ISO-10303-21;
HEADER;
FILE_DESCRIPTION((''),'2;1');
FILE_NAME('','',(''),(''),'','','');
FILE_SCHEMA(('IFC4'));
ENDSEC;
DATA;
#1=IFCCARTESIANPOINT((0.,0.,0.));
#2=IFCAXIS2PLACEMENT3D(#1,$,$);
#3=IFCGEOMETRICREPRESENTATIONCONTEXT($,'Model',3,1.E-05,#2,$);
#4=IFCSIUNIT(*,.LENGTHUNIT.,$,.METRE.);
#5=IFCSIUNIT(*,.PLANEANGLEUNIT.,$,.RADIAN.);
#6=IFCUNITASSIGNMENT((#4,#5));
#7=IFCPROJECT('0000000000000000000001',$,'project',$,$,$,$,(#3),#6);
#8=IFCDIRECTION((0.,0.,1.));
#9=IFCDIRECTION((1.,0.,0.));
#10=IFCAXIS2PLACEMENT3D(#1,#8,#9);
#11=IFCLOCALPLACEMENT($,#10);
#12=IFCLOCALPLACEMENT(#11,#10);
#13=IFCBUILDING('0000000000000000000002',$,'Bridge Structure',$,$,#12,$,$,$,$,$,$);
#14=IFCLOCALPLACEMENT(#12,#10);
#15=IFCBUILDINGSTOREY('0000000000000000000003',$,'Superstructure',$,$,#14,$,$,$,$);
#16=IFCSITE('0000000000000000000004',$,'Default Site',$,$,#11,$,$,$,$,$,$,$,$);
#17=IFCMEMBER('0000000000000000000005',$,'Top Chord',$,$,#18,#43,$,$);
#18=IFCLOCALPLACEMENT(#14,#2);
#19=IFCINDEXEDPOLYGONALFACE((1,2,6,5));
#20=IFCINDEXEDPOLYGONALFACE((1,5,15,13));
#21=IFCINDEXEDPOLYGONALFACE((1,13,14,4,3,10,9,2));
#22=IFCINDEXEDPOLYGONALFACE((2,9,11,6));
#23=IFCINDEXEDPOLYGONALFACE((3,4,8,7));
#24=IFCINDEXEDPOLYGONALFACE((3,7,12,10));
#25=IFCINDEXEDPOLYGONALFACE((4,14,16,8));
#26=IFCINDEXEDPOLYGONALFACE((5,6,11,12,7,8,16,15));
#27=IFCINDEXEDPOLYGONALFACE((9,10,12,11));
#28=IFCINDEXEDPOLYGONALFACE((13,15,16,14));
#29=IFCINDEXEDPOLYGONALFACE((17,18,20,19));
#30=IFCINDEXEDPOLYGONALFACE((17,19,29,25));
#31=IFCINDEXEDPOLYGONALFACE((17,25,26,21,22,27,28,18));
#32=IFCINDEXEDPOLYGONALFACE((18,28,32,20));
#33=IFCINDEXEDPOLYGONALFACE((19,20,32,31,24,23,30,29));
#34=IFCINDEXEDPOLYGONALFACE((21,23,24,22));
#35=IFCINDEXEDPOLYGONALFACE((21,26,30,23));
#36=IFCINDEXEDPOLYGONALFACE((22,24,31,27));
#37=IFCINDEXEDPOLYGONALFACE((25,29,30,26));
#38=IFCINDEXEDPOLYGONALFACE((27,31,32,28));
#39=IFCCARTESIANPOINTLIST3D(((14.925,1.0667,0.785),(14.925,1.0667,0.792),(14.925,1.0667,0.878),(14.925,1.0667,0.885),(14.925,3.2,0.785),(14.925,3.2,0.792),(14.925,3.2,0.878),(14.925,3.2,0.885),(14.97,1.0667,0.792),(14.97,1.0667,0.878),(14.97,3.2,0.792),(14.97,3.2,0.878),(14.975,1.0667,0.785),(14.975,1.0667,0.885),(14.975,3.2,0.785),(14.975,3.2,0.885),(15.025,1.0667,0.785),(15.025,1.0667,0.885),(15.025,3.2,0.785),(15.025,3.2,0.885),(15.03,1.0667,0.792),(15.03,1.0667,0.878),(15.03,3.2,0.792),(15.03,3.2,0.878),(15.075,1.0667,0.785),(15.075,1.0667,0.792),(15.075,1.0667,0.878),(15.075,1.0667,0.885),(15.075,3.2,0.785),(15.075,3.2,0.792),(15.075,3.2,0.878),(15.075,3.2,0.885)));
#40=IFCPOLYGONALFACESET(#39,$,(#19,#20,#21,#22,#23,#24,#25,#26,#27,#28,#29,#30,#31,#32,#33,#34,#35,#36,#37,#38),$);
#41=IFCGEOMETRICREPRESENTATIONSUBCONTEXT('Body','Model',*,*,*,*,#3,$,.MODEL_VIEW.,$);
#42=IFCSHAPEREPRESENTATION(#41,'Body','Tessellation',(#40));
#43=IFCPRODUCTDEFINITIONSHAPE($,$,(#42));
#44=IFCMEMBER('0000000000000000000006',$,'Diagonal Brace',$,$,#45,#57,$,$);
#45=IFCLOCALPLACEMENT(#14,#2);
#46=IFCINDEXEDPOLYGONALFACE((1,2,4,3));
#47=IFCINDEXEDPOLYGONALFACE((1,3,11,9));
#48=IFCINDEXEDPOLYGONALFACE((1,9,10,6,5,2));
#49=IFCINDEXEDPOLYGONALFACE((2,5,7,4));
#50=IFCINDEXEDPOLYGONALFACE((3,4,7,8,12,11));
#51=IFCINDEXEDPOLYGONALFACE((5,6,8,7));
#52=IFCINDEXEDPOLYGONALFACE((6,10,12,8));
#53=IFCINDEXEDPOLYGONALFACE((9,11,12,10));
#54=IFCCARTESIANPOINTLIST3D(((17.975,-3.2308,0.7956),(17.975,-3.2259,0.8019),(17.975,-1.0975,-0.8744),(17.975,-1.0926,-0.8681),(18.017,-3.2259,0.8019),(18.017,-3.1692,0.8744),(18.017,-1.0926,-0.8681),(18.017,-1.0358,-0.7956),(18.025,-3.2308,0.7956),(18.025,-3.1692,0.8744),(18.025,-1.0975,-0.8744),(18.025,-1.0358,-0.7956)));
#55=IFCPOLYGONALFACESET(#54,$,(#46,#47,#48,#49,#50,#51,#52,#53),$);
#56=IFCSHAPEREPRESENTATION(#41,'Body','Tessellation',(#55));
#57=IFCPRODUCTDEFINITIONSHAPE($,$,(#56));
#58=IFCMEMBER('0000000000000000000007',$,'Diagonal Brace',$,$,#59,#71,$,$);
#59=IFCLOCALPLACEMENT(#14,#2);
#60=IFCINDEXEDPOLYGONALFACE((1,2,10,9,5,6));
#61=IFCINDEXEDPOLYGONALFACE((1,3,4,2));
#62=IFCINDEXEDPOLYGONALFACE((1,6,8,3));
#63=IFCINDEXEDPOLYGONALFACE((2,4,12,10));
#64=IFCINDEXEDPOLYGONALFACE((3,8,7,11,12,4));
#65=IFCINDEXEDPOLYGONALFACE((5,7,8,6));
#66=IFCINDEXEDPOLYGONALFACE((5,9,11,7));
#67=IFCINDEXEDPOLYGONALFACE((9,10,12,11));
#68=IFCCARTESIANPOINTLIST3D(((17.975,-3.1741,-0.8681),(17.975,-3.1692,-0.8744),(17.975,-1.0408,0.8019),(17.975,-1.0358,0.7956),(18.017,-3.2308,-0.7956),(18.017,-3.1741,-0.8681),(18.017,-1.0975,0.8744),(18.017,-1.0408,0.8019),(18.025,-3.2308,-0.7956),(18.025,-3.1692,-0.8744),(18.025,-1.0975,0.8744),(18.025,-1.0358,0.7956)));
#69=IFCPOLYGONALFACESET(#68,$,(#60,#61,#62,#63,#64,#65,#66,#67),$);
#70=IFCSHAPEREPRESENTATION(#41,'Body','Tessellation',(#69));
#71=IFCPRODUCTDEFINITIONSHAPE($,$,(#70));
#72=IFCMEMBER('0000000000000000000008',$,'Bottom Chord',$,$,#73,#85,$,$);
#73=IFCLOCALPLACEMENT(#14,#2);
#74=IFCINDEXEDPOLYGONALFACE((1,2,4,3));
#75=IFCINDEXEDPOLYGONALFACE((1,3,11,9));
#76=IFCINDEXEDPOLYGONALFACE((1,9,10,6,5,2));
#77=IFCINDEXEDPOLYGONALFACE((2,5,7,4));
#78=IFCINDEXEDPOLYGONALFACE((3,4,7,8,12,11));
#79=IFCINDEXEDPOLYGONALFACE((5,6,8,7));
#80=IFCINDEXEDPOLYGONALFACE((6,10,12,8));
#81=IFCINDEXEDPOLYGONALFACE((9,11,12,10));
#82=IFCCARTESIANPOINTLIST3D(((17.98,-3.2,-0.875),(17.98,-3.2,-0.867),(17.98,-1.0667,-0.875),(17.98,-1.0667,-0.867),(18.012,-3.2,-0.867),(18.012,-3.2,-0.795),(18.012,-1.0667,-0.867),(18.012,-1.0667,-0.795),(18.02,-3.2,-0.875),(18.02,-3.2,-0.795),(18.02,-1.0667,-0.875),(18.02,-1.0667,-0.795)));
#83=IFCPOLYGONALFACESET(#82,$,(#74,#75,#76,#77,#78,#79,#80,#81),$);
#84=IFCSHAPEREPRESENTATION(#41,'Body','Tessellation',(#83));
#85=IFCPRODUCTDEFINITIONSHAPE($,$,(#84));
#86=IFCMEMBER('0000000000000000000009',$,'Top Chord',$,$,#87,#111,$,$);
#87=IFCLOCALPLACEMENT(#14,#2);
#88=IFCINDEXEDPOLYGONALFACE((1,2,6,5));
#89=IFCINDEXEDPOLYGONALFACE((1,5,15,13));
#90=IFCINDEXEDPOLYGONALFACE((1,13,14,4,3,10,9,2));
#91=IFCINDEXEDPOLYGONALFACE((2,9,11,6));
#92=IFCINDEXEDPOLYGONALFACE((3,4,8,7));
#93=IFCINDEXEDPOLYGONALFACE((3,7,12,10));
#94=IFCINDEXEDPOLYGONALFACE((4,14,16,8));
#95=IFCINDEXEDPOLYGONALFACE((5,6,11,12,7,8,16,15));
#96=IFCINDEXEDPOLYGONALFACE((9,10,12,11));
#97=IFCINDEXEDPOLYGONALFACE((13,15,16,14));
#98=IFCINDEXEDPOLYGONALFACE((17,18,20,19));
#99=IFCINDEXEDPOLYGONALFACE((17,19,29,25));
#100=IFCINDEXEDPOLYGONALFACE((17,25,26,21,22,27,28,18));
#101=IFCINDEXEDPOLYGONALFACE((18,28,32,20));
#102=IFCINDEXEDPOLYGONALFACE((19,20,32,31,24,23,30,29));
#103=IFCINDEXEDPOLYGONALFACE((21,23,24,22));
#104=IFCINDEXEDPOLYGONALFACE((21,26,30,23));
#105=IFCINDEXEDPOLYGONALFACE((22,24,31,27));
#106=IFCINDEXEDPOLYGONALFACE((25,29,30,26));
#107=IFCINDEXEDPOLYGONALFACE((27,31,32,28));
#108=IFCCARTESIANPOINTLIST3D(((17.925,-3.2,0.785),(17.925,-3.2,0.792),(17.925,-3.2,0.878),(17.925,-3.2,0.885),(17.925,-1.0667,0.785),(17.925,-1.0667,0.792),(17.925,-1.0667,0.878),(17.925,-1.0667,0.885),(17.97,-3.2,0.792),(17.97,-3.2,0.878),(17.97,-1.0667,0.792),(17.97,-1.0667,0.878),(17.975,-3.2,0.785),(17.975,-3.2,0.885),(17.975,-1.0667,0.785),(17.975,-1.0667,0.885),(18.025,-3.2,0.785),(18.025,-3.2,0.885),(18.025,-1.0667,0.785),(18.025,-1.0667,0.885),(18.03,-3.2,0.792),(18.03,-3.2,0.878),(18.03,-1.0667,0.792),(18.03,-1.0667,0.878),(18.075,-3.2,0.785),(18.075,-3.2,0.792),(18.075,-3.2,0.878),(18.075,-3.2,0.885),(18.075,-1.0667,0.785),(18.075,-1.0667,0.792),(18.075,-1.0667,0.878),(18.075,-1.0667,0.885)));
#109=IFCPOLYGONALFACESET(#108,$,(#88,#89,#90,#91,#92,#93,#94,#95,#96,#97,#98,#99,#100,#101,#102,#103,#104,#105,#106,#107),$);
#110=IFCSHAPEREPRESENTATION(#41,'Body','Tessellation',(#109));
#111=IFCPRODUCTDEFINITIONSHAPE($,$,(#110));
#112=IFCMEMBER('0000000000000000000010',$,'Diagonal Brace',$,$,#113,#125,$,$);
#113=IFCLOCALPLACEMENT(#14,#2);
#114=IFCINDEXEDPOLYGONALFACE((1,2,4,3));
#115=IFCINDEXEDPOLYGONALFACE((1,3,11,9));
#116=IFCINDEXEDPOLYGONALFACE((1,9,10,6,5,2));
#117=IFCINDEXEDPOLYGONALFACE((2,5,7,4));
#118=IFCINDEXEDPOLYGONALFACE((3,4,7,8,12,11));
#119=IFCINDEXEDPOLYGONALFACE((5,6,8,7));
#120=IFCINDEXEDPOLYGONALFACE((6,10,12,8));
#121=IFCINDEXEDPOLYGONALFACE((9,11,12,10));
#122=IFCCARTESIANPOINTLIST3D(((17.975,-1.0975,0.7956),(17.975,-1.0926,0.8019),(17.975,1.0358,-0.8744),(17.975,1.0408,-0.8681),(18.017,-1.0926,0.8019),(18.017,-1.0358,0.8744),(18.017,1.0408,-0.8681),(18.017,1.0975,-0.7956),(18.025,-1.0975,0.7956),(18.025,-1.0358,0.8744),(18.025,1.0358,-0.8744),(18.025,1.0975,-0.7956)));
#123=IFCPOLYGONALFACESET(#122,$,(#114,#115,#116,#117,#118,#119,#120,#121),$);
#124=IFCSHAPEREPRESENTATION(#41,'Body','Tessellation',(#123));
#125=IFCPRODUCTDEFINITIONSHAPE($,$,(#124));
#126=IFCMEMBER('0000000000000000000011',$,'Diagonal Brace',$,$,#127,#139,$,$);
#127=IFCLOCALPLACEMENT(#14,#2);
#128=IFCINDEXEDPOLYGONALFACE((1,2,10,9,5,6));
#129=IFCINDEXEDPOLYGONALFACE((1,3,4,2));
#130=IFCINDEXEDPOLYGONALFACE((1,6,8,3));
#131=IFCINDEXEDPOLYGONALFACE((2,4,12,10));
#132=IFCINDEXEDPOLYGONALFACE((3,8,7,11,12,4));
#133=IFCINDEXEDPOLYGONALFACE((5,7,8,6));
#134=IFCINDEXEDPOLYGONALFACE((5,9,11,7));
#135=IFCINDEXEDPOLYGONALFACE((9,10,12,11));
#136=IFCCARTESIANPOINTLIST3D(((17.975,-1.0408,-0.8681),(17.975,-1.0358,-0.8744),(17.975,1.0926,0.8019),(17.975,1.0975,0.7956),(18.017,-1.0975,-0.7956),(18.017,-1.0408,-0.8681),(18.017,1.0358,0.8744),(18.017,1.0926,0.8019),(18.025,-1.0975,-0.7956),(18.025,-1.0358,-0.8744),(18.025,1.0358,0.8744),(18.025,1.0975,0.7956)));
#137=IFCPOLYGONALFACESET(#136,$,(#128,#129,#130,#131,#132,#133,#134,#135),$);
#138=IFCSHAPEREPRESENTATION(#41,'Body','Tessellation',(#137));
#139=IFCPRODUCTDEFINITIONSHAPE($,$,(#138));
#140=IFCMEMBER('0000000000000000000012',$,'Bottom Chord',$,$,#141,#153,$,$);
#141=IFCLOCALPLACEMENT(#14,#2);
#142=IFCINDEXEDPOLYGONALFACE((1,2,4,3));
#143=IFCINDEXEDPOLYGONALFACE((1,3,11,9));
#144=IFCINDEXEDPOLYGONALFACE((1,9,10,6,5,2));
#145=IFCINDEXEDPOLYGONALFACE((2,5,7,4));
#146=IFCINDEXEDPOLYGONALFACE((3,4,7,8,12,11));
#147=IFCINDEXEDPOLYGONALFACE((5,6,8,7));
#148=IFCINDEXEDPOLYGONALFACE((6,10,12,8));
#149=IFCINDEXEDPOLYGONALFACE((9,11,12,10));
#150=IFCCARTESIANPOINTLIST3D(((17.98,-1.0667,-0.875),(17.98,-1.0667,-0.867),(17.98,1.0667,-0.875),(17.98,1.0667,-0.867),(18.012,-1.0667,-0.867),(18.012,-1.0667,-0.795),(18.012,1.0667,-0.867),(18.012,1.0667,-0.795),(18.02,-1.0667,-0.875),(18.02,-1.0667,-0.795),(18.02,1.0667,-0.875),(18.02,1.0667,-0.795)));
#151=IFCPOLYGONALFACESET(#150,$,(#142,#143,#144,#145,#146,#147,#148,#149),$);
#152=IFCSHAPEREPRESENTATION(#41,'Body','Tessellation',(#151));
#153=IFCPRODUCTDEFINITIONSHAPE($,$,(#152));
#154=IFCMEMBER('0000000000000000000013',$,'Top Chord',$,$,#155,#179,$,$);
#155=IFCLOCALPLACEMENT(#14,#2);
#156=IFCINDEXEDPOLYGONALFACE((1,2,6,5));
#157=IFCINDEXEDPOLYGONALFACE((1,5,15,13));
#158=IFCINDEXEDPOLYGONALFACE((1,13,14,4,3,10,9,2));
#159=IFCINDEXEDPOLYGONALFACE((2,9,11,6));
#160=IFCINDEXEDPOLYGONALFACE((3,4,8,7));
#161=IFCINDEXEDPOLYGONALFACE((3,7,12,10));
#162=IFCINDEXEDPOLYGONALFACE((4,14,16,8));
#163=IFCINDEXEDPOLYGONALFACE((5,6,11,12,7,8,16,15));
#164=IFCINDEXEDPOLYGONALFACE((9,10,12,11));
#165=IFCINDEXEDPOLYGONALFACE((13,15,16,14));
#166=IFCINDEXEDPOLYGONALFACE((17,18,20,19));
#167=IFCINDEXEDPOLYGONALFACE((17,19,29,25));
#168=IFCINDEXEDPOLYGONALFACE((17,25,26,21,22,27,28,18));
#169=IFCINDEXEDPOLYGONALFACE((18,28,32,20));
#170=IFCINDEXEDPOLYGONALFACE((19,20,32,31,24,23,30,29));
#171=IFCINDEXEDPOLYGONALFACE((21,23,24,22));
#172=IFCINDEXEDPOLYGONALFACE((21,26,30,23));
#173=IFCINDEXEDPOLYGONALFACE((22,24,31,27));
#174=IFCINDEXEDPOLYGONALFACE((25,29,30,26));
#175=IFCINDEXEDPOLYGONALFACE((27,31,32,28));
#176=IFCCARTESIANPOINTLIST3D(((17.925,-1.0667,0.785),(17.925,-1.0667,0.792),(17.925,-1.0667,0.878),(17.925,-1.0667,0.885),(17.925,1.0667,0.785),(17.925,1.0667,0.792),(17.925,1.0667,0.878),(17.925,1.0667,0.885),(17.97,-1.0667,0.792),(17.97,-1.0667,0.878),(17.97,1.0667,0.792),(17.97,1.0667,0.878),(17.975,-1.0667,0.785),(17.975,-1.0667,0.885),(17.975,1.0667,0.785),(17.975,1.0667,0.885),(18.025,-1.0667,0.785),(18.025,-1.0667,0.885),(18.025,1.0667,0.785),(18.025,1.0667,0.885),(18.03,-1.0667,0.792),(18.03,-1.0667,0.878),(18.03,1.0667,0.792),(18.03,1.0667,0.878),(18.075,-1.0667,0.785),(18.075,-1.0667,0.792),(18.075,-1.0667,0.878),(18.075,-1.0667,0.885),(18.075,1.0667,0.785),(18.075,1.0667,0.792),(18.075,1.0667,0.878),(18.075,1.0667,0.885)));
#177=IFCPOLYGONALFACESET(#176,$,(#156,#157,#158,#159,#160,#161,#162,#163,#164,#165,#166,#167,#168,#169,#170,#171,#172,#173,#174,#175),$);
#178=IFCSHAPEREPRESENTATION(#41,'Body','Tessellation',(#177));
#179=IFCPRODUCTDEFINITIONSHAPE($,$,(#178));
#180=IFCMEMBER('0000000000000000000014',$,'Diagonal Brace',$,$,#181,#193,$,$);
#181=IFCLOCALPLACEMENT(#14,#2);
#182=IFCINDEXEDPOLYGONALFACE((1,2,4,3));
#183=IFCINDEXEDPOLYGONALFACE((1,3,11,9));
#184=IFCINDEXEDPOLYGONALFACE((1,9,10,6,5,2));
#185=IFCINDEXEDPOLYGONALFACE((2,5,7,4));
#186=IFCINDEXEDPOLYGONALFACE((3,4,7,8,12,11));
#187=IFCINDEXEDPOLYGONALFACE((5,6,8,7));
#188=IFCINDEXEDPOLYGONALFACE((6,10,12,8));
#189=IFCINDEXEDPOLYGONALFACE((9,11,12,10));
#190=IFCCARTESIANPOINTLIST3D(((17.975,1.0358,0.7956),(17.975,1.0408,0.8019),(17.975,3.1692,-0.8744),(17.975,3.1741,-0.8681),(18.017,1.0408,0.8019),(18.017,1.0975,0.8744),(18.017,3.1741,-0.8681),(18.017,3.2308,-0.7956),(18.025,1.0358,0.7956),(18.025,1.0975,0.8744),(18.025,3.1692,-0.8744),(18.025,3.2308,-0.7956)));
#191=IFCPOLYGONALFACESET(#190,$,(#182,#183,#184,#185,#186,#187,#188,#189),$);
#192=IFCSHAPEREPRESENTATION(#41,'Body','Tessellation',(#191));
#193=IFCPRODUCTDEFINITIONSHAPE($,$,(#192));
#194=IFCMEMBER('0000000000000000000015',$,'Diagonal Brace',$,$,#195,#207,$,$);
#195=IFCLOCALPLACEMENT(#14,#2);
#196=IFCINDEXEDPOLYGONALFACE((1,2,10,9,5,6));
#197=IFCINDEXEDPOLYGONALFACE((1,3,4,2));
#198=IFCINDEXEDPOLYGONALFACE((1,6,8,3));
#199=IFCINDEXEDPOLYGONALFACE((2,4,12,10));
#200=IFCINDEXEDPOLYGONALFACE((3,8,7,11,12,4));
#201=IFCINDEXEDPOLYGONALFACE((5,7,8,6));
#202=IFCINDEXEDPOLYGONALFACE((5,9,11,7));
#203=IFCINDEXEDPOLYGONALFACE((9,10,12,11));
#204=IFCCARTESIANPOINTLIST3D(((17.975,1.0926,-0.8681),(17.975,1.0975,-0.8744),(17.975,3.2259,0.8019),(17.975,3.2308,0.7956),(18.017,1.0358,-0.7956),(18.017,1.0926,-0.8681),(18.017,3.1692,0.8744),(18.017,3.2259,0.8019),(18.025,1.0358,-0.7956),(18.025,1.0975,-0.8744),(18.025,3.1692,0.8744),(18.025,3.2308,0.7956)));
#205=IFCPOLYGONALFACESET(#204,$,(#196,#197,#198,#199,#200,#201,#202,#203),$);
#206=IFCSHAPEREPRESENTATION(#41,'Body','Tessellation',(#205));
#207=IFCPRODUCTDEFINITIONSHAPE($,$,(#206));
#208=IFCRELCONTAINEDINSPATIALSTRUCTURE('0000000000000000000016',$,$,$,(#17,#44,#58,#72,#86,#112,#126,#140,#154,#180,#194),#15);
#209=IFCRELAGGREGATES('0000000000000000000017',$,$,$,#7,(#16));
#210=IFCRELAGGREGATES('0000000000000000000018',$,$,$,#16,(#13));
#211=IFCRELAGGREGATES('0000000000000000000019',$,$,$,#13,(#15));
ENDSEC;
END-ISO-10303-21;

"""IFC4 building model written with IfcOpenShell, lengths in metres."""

from ifc_helpers import new_model, si_unit, frame, origin, origin_with_axes, origin_2d_with_axis, place, context, subcontext, project, spatial, polyline, l_section, outline, composite_profile, extrude, element, save


model = new_model("IFC4")

# Units and contexts
model_context = context("Model", 3, precision=1e-05, world=origin())
body_context = subcontext(model_context, "Body", "Model", "MODEL_VIEW")
ifc_project = project(units=[si_unit("LENGTHUNIT", "METRE"), si_unit("PLANEANGLEUNIT", "RADIAN")], contexts=[model_context])

# Site, building, storey
site_placement = place(None, origin_with_axes())
site = spatial("IfcSite", under=ifc_project, at=site_placement, Name="Default Site")
building_placement = place(site_placement, origin_with_axes())
building = spatial("IfcBuilding", under=site, at=building_placement, Name="Bridge Structure")
storey_placement = place(building_placement, origin_with_axes())
storey = spatial("IfcBuildingStorey", under=building, at=storey_placement, Name="Superstructure")

# Members
member_1_placement = place(storey_placement, frame((15.0, 1.0667, 0.835), z_axis=(0.0, 1.0, 0.0), x_axis=(-1.0, 0.0, 0.0)))
element("IfcMember", 1, at=member_1_placement, inside=storey, Name="Top Chord", context=body_context, shape_type="SweptSolid", body=[
    extrude(composite_profile([outline(polyline([(-0.025, -0.05), (-0.025, 0.05), (-0.075, 0.05), (-0.075, 0.043), (-0.03, 0.043), (-0.03, -0.043), (-0.075, -0.043), (-0.075, -0.05), (-0.025, -0.05)])), outline(polyline([(0.025, -0.05), (0.075, -0.05), (0.075, -0.043), (0.03, -0.043), (0.03, 0.043), (0.075, 0.043), (0.075, 0.05), (0.025, 0.05), (0.025, -0.05)]))]), origin_with_axes(), (0.0, 0.0, 1.0), 2.1333),
])
for number, where, z_axis, x_axis, name in (
    (2, (18.0, -3.2, 0.835), (0.0, 0.787427, -0.616408), (-1.0, 0.0, 0.0), "Diagonal Brace"),
    (3, (18.0, -3.2, -0.835), (0.0, 0.787427, 0.616408), (-1.0, 0.0, 0.0), "Diagonal Brace"),
):
    element("IfcMember", number, at=place(storey_placement, frame(where, z_axis=z_axis, x_axis=x_axis)), inside=storey, Name=name, context=body_context, shape_type="SweptSolid", body=[
        extrude(l_section(Depth=0.1, Width=0.05, Thickness=0.008, at=origin_2d_with_axis()), origin_with_axes(), (0.0, 0.0, 1.0), 2.7092),
    ])
member_2_placement = place(storey_placement, frame((18.0, -3.2, -0.835), z_axis=(0.0, 1.0, 0.0), x_axis=(-1.0, 0.0, 0.0)))
element("IfcMember", 4, at=member_2_placement, inside=storey, Name="Bottom Chord", context=body_context, shape_type="SweptSolid", body=[
    extrude(l_section(Depth=0.08, Width=0.04, Thickness=0.008, at=origin_2d_with_axis()), origin_with_axes(), (0.0, 0.0, 1.0), 2.1333),
])
member_3_placement = place(storey_placement, frame((18.0, -3.2, 0.835), z_axis=(0.0, 1.0, 0.0), x_axis=(-1.0, 0.0, 0.0)))
element("IfcMember", 5, at=member_3_placement, inside=storey, Name="Top Chord", context=body_context, shape_type="SweptSolid", body=[
    extrude(composite_profile([outline(polyline([(-0.025, -0.05), (-0.025, 0.05), (-0.075, 0.05), (-0.075, 0.043), (-0.03, 0.043), (-0.03, -0.043), (-0.075, -0.043), (-0.075, -0.05), (-0.025, -0.05)])), outline(polyline([(0.025, -0.05), (0.075, -0.05), (0.075, -0.043), (0.03, -0.043), (0.03, 0.043), (0.075, 0.043), (0.075, 0.05), (0.025, 0.05), (0.025, -0.05)]))]), origin_with_axes(), (0.0, 0.0, 1.0), 2.1333),
])
for number, where, z_axis, x_axis, name in (
    (6, (18.0, -1.0667, 0.835), (0.0, 0.787427, -0.616408), (-1.0, 0.0, 0.0), "Diagonal Brace"),
    (7, (18.0, -1.0667, -0.835), (0.0, 0.787427, 0.616408), (-1.0, 0.0, 0.0), "Diagonal Brace"),
):
    element("IfcMember", number, at=place(storey_placement, frame(where, z_axis=z_axis, x_axis=x_axis)), inside=storey, Name=name, context=body_context, shape_type="SweptSolid", body=[
        extrude(l_section(Depth=0.1, Width=0.05, Thickness=0.008, at=origin_2d_with_axis()), origin_with_axes(), (0.0, 0.0, 1.0), 2.7092),
    ])
member_4_placement = place(storey_placement, frame((18.0, -1.0667, -0.835), z_axis=(0.0, 1.0, 0.0), x_axis=(-1.0, 0.0, 0.0)))
element("IfcMember", 8, at=member_4_placement, inside=storey, Name="Bottom Chord", context=body_context, shape_type="SweptSolid", body=[
    extrude(l_section(Depth=0.08, Width=0.04, Thickness=0.008, at=origin_2d_with_axis()), origin_with_axes(), (0.0, 0.0, 1.0), 2.1333),
])
member_5_placement = place(storey_placement, frame((18.0, -1.0667, 0.835), z_axis=(0.0, 1.0, 0.0), x_axis=(-1.0, 0.0, 0.0)))
element("IfcMember", 9, at=member_5_placement, inside=storey, Name="Top Chord", context=body_context, shape_type="SweptSolid", body=[
    extrude(composite_profile([outline(polyline([(-0.025, -0.05), (-0.025, 0.05), (-0.075, 0.05), (-0.075, 0.043), (-0.03, 0.043), (-0.03, -0.043), (-0.075, -0.043), (-0.075, -0.05), (-0.025, -0.05)])), outline(polyline([(0.025, -0.05), (0.075, -0.05), (0.075, -0.043), (0.03, -0.043), (0.03, 0.043), (0.075, 0.043), (0.075, 0.05), (0.025, 0.05), (0.025, -0.05)]))]), origin_with_axes(), (0.0, 0.0, 1.0), 2.1333),
])
for number, where, z_axis, x_axis, name in (
    (10, (18.0, 1.0667, 0.835), (0.0, 0.787427, -0.616408), (-1.0, 0.0, 0.0), "Diagonal Brace"),
    (11, (18.0, 1.0667, -0.835), (0.0, 0.787427, 0.616408), (-1.0, 0.0, 0.0), "Diagonal Brace"),
):
    element("IfcMember", number, at=place(storey_placement, frame(where, z_axis=z_axis, x_axis=x_axis)), inside=storey, Name=name, context=body_context, shape_type="SweptSolid", body=[
        extrude(l_section(Depth=0.1, Width=0.05, Thickness=0.008, at=origin_2d_with_axis()), origin_with_axes(), (0.0, 0.0, 1.0), 2.7092),
    ])

save(model, "model.ifc")
